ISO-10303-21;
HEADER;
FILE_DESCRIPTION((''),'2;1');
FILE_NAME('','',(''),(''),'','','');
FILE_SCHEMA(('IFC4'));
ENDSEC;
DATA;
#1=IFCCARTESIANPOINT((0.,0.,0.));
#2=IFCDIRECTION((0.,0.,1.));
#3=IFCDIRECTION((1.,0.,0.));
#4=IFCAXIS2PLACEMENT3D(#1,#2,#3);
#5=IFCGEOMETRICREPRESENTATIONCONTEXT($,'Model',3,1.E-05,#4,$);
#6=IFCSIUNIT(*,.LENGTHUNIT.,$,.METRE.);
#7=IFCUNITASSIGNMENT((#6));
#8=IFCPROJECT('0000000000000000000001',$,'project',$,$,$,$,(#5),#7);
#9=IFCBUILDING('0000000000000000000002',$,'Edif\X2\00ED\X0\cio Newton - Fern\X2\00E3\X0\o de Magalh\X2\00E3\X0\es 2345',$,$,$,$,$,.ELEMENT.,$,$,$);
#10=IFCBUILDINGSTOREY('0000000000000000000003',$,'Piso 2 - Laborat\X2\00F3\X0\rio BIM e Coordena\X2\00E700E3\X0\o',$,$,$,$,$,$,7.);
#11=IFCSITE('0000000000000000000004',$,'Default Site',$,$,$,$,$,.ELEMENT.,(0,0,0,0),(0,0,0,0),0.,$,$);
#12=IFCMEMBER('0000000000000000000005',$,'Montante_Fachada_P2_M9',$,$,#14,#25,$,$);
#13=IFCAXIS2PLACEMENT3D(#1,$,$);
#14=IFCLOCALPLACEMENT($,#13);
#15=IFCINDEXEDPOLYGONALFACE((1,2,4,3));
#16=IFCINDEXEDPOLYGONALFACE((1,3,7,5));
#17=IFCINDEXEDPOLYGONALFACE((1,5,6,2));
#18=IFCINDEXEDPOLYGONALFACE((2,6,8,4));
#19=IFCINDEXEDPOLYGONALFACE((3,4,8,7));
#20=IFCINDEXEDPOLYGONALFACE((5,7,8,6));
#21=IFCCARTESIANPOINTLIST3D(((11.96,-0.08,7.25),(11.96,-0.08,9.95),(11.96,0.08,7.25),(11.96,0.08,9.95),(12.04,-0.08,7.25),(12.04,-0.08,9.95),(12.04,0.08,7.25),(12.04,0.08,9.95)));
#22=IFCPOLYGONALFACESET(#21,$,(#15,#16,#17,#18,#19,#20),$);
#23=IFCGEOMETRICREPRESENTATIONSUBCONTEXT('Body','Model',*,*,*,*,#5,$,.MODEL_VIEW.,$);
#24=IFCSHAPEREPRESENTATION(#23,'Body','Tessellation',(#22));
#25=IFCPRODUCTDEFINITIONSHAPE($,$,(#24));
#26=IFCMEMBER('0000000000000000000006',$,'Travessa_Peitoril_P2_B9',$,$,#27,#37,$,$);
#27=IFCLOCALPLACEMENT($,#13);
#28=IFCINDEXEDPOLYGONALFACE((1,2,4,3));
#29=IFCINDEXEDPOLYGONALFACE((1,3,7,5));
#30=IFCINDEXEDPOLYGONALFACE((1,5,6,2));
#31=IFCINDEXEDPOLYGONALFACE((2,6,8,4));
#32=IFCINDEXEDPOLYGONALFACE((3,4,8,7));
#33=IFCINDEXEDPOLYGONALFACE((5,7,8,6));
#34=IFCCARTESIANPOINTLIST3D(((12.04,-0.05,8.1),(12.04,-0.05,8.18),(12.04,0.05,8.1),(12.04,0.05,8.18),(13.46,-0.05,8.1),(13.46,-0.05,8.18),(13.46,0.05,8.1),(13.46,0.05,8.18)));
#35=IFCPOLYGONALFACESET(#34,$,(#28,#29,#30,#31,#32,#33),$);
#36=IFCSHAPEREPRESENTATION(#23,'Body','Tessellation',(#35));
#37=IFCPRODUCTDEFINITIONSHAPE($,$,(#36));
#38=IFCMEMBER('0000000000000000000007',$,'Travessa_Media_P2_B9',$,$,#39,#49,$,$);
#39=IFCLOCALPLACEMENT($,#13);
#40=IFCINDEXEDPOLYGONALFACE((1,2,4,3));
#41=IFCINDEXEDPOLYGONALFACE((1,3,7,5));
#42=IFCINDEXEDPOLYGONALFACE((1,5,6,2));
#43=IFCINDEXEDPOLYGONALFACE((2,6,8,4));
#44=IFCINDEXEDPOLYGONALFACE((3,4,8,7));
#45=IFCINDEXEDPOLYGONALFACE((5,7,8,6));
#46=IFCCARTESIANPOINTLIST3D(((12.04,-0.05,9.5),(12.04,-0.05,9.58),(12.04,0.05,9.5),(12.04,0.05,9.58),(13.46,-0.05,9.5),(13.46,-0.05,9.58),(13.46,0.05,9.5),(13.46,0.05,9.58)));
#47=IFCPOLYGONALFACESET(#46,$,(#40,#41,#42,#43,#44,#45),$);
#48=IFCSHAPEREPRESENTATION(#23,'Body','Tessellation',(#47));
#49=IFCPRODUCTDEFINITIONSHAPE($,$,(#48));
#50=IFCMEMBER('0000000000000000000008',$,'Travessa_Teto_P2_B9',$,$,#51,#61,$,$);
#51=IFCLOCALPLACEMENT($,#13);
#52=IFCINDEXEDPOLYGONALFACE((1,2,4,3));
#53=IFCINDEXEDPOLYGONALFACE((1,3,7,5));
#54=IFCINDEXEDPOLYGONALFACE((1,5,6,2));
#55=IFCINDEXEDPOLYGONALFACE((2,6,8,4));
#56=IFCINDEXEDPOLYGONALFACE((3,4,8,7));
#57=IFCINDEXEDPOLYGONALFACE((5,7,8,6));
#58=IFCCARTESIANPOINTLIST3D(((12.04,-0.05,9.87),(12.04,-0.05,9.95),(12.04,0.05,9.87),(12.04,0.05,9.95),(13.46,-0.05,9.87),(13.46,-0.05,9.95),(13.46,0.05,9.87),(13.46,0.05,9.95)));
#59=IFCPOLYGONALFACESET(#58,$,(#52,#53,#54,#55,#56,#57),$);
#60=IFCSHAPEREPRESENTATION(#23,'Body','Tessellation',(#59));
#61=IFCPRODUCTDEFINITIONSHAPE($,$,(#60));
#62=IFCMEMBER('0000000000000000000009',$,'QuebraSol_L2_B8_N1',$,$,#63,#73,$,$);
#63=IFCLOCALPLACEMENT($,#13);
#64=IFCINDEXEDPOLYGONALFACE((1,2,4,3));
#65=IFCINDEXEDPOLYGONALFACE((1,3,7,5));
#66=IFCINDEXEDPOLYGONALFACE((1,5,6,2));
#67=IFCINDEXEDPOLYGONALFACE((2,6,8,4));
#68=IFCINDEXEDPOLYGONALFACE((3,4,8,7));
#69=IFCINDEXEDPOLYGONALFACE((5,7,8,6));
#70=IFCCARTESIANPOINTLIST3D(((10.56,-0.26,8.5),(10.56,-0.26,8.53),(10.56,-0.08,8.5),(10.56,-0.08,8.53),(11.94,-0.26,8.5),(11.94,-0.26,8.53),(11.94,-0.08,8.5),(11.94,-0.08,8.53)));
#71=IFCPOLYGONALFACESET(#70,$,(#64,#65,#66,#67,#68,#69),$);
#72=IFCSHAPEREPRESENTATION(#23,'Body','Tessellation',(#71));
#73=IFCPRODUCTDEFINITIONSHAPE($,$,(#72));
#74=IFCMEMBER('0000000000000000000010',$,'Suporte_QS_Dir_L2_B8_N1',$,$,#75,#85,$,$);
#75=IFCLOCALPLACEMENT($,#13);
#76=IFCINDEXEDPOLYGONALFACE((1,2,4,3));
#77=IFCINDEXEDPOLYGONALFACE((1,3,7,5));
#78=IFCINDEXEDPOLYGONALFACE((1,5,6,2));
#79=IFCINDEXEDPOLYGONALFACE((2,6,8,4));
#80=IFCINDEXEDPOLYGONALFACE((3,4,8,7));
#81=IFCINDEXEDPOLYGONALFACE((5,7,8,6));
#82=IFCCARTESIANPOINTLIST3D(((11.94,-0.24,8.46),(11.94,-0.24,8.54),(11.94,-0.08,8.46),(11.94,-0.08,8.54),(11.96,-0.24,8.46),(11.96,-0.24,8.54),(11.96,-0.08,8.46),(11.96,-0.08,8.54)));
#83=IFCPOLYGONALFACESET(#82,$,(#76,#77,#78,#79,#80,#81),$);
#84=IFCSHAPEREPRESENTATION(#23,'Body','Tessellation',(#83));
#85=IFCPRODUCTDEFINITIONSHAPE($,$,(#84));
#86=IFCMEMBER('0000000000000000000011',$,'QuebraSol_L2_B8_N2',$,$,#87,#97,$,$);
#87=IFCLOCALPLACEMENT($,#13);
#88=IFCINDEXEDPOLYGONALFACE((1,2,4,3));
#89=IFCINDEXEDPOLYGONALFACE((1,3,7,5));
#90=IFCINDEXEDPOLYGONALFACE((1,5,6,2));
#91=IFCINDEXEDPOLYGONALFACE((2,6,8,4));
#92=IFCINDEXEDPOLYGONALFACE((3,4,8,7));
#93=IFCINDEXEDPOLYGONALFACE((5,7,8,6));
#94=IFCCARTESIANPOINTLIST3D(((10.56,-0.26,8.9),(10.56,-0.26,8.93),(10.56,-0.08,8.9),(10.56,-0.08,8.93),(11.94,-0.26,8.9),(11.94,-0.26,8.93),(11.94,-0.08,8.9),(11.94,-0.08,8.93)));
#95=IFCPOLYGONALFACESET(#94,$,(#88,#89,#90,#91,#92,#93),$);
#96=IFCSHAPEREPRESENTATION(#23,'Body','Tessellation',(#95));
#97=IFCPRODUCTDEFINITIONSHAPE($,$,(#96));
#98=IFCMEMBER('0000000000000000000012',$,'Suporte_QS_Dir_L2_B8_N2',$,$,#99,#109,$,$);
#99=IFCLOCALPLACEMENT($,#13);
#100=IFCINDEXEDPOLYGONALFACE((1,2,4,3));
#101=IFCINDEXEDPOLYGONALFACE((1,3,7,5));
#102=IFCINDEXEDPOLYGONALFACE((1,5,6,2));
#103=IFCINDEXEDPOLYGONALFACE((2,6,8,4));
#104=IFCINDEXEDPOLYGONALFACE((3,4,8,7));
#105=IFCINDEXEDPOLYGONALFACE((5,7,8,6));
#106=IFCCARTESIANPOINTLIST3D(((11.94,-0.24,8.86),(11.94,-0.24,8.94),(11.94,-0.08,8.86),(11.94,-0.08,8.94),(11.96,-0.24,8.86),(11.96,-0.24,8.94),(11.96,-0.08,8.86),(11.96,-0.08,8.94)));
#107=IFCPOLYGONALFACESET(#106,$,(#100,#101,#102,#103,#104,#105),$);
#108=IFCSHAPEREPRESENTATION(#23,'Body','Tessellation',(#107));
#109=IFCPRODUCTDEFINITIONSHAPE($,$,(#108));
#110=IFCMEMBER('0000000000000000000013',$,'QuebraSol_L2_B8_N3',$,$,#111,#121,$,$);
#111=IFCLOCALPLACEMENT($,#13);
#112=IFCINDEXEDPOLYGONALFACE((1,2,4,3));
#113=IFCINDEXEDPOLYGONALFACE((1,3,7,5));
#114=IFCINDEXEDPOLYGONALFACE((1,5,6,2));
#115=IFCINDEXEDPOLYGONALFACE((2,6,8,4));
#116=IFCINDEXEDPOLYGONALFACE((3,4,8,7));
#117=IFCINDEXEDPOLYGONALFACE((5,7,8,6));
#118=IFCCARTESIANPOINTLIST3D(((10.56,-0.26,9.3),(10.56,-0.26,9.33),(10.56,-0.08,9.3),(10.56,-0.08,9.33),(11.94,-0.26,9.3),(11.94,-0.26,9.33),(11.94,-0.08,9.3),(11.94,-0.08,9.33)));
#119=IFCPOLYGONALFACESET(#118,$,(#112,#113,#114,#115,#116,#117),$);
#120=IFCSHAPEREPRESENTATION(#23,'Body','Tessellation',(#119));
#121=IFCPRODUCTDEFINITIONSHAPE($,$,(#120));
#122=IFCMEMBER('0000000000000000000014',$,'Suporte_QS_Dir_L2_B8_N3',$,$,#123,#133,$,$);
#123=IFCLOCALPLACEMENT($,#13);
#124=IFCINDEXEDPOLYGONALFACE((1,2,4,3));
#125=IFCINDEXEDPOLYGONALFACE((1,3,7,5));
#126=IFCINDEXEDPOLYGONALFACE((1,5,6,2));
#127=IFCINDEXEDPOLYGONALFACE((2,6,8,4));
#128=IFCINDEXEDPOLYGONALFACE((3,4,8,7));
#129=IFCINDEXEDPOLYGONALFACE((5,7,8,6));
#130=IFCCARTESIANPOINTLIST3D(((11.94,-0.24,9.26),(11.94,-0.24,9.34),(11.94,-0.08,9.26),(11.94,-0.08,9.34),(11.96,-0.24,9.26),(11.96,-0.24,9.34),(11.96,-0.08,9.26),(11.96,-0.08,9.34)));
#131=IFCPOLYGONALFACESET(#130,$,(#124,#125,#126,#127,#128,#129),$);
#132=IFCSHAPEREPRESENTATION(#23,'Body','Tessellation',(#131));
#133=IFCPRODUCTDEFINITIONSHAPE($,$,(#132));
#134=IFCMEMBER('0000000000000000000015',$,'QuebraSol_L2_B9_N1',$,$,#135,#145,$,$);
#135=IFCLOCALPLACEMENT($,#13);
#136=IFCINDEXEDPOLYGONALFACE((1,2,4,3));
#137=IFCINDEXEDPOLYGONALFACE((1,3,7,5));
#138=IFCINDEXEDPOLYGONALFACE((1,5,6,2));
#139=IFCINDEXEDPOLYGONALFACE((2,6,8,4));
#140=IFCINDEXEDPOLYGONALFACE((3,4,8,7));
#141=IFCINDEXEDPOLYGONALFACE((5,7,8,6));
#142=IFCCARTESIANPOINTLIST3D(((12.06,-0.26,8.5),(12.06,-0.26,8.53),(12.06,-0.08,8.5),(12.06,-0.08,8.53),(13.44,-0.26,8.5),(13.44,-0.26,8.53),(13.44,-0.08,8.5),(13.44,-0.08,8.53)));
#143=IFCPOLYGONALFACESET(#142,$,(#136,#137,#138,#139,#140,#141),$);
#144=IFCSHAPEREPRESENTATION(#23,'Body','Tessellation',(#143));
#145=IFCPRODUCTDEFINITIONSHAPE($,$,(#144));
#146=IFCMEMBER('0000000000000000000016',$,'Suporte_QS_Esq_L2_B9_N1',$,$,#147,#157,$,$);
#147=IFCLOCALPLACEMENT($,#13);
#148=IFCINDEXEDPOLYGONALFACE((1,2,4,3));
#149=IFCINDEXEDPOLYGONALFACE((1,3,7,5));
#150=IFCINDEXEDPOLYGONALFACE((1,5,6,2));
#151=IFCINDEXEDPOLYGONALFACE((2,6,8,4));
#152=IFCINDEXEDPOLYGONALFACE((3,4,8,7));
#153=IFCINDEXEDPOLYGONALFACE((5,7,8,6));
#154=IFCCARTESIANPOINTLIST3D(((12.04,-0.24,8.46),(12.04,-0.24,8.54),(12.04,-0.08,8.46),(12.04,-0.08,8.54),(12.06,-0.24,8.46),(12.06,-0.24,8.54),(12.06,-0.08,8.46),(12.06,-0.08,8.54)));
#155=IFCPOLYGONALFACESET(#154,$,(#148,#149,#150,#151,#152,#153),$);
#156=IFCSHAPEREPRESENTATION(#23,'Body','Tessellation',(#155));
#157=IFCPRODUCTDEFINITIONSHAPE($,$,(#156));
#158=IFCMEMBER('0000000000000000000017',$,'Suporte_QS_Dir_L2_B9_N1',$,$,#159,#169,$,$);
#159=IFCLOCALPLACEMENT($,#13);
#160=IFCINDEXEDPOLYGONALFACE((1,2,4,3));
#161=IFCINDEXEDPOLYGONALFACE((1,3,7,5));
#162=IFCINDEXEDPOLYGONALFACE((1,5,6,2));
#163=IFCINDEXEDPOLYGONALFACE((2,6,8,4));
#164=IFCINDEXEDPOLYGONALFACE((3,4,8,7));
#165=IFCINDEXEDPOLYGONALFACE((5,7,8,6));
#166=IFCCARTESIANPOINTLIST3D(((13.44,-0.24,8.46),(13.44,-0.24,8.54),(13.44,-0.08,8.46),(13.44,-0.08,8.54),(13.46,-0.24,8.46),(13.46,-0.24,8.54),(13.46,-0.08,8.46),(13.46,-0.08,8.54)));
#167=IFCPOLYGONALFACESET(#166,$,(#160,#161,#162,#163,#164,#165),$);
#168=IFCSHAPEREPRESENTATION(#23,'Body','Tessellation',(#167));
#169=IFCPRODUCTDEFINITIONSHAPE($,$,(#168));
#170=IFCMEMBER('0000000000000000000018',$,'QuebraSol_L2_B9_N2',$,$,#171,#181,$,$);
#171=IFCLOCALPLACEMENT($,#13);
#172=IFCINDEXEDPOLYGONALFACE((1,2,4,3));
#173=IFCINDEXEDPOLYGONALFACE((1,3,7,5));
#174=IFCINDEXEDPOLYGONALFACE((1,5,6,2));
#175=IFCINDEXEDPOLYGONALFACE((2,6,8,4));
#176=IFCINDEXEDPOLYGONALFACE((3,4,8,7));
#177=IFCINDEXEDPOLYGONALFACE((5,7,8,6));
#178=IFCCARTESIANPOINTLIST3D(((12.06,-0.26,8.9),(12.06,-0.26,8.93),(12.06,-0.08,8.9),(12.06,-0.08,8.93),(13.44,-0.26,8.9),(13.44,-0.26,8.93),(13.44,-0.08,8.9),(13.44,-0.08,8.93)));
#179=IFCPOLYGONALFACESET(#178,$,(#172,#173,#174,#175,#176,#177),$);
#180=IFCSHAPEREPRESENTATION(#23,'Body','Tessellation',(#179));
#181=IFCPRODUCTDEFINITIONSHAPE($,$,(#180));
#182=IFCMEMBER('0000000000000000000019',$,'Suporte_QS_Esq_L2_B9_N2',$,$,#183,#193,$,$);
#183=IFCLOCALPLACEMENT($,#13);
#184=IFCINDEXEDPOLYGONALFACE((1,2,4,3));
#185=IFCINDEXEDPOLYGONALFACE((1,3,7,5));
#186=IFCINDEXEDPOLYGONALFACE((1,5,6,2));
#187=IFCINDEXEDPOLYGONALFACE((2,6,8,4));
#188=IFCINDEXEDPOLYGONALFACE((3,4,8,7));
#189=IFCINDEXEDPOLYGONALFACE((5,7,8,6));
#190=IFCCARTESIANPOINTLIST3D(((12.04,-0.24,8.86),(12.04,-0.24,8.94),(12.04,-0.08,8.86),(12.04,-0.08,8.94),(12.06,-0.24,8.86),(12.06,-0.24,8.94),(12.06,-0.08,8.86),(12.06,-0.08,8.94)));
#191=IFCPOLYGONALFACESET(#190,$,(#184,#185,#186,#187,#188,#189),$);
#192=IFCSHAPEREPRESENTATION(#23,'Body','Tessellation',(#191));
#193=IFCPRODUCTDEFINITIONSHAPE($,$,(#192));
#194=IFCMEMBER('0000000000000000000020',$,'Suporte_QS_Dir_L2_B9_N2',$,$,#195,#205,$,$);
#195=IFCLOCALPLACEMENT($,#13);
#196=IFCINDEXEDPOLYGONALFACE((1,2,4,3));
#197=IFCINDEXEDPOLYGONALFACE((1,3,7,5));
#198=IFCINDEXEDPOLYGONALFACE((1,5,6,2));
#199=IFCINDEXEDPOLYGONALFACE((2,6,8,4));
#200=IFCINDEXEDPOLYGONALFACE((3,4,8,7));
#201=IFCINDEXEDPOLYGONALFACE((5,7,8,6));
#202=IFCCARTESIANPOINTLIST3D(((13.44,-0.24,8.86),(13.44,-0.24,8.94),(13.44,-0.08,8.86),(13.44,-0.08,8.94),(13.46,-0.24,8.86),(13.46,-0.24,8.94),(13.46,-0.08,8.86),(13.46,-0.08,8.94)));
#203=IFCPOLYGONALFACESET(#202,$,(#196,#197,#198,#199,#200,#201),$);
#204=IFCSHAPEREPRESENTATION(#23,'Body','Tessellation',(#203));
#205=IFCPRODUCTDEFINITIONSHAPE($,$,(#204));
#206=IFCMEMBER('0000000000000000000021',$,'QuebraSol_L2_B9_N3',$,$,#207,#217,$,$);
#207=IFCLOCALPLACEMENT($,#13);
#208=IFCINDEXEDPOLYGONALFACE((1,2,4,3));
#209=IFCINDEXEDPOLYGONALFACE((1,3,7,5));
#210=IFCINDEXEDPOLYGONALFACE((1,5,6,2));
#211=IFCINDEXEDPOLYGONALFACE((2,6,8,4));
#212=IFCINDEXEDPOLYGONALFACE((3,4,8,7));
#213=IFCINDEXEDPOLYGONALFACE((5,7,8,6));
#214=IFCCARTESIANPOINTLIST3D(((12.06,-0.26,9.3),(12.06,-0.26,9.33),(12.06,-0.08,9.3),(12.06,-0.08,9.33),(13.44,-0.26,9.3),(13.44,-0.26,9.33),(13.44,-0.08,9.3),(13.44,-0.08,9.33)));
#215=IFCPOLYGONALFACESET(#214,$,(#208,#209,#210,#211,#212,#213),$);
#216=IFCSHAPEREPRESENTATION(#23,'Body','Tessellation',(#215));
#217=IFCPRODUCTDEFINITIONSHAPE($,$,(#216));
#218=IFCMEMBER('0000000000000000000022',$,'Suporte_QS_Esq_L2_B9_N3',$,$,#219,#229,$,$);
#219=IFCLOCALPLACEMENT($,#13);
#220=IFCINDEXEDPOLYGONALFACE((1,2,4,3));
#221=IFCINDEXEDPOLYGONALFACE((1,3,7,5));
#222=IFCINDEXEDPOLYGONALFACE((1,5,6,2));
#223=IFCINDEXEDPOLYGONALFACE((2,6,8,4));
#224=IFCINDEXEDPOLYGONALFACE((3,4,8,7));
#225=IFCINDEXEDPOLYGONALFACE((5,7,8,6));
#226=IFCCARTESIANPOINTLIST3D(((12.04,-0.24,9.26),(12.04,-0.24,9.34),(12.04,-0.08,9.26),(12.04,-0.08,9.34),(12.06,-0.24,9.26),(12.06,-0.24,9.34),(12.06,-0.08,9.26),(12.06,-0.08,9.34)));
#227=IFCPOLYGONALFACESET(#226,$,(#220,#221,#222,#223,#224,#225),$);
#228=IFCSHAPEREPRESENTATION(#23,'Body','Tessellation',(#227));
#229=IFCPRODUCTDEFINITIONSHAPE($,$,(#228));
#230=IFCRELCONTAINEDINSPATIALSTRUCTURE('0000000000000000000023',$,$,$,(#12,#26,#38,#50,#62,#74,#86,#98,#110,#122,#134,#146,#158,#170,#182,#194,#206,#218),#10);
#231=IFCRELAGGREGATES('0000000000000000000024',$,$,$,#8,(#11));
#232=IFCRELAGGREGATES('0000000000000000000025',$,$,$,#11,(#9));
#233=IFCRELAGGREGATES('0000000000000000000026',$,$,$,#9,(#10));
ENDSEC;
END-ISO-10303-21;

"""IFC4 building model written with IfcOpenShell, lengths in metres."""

from ifc_helpers import new_model, si_unit, frame, frame_2d, origin_with_axes, place, context, subcontext, project, spatial, rectangle, extrude, element, save


model = new_model("IFC4")

# Units and contexts
model_context = context("Model", 3, precision=1e-05, world=origin_with_axes())
body_context = subcontext(model_context, "Body", "Model", "MODEL_VIEW")
ifc_project = project(units=[si_unit("LENGTHUNIT", "METRE")], contexts=[model_context])

# Site, building, storey
site = spatial("IfcSite", under=ifc_project, Name="Default Site", CompositionType="ELEMENT", RefLatitude=(0, 0, 0, 0), RefLongitude=(0, 0, 0, 0), RefElevation=0.0)
building = spatial("IfcBuilding", under=site, Name="Edifício Newton - Fernão de Magalhães 2345", CompositionType="ELEMENT")
storey = spatial("IfcBuildingStorey", under=building, Name="Piso 2 - Laboratório BIM e Coordenação", Elevation=7.0)

# Members
member_1_placement = place(None, frame((11.96, -0.08, 7.25), z_axis=(0.0, 0.0, 1.0), x_axis=(1.0, 0.0, 0.0)))
element("IfcMember", 1, at=member_1_placement, inside=storey, Name="Montante_Fachada_P2_M9", context=body_context, shape_type="SweptSolid", body=[
    extrude(rectangle(XDim=0.08, YDim=0.16, at=frame_2d((0.04, 0.08))), origin_with_axes(), (0.0, 0.0, 1.0), 2.7),
])
for number, where, z_axis, x_axis, name in (
    (2, (12.04, -0.05, 8.1), (0.0, 0.0, 1.0), (1.0, 0.0, 0.0), "Travessa_Peitoril_P2_B9"),
    (3, (12.04, -0.05, 9.5), (0.0, 0.0, 1.0), (1.0, 0.0, 0.0), "Travessa_Media_P2_B9"),
    (4, (12.04, -0.05, 9.87), (0.0, 0.0, 1.0), (1.0, 0.0, 0.0), "Travessa_Teto_P2_B9"),
):
    element("IfcMember", number, at=place(None, frame(where, z_axis=z_axis, x_axis=x_axis)), inside=storey, Name=name, context=body_context, shape_type="SweptSolid", body=[
        extrude(rectangle(XDim=1.42, YDim=0.1, at=frame_2d((0.71, 0.05))), origin_with_axes(), (0.0, 0.0, 1.0), 0.08),
    ])
member_2_placement = place(None, frame((10.56, -0.26, 8.5), z_axis=(0.0, 0.0, 1.0), x_axis=(1.0, 0.0, 0.0)))
element("IfcMember", 5, at=member_2_placement, inside=storey, Name="QuebraSol_L2_B8_N1", context=body_context, shape_type="SweptSolid", body=[
    extrude(rectangle(XDim=1.38, YDim=0.18, at=frame_2d((0.69, 0.09))), origin_with_axes(), (0.0, 0.0, 1.0), 0.03),
])
member_3_placement = place(None, frame((11.94, -0.24, 8.46), z_axis=(0.0, 0.0, 1.0), x_axis=(1.0, 0.0, 0.0)))
element("IfcMember", 6, at=member_3_placement, inside=storey, Name="Suporte_QS_Dir_L2_B8_N1", context=body_context, shape_type="SweptSolid", body=[
    extrude(rectangle(XDim=0.02, YDim=0.16, at=frame_2d((0.01, 0.08))), origin_with_axes(), (0.0, 0.0, 1.0), 0.08),
])
member_4_placement = place(None, frame((10.56, -0.26, 8.9), z_axis=(0.0, 0.0, 1.0), x_axis=(1.0, 0.0, 0.0)))
element("IfcMember", 7, at=member_4_placement, inside=storey, Name="QuebraSol_L2_B8_N2", context=body_context, shape_type="SweptSolid", body=[
    extrude(rectangle(XDim=1.38, YDim=0.18, at=frame_2d((0.69, 0.09))), origin_with_axes(), (0.0, 0.0, 1.0), 0.03),
])
member_5_placement = place(None, frame((11.94, -0.24, 8.86), z_axis=(0.0, 0.0, 1.0), x_axis=(1.0, 0.0, 0.0)))
element("IfcMember", 8, at=member_5_placement, inside=storey, Name="Suporte_QS_Dir_L2_B8_N2", context=body_context, shape_type="SweptSolid", body=[
    extrude(rectangle(XDim=0.02, YDim=0.16, at=frame_2d((0.01, 0.08))), origin_with_axes(), (0.0, 0.0, 1.0), 0.08),
])
member_6_placement = place(None, frame((10.56, -0.26, 9.3), z_axis=(0.0, 0.0, 1.0), x_axis=(1.0, 0.0, 0.0)))
element("IfcMember", 9, at=member_6_placement, inside=storey, Name="QuebraSol_L2_B8_N3", context=body_context, shape_type="SweptSolid", body=[
    extrude(rectangle(XDim=1.38, YDim=0.18, at=frame_2d((0.69, 0.09))), origin_with_axes(), (0.0, 0.0, 1.0), 0.03),
])
member_7_placement = place(None, frame((11.94, -0.24, 9.26), z_axis=(0.0, 0.0, 1.0), x_axis=(1.0, 0.0, 0.0)))
element("IfcMember", 10, at=member_7_placement, inside=storey, Name="Suporte_QS_Dir_L2_B8_N3", context=body_context, shape_type="SweptSolid", body=[
    extrude(rectangle(XDim=0.02, YDim=0.16, at=frame_2d((0.01, 0.08))), origin_with_axes(), (0.0, 0.0, 1.0), 0.08),
])
member_8_placement = place(None, frame((12.06, -0.26, 8.5), z_axis=(0.0, 0.0, 1.0), x_axis=(1.0, 0.0, 0.0)))
element("IfcMember", 11, at=member_8_placement, inside=storey, Name="QuebraSol_L2_B9_N1", context=body_context, shape_type="SweptSolid", body=[
    extrude(rectangle(XDim=1.38, YDim=0.18, at=frame_2d((0.69, 0.09))), origin_with_axes(), (0.0, 0.0, 1.0), 0.03),
])
for number, where, z_axis, x_axis, name in (
    (12, (12.04, -0.24, 8.46), (0.0, 0.0, 1.0), (1.0, 0.0, 0.0), "Suporte_QS_Esq_L2_B9_N1"),
    (13, (13.44, -0.24, 8.46), (0.0, 0.0, 1.0), (1.0, 0.0, 0.0), "Suporte_QS_Dir_L2_B9_N1"),
):
    element("IfcMember", number, at=place(None, frame(where, z_axis=z_axis, x_axis=x_axis)), inside=storey, Name=name, context=body_context, shape_type="SweptSolid", body=[
        extrude(rectangle(XDim=0.02, YDim=0.16, at=frame_2d((0.01, 0.08))), origin_with_axes(), (0.0, 0.0, 1.0), 0.08),
    ])
member_9_placement = place(None, frame((12.06, -0.26, 8.9), z_axis=(0.0, 0.0, 1.0), x_axis=(1.0, 0.0, 0.0)))
element("IfcMember", 14, at=member_9_placement, inside=storey, Name="QuebraSol_L2_B9_N2", context=body_context, shape_type="SweptSolid", body=[
    extrude(rectangle(XDim=1.38, YDim=0.18, at=frame_2d((0.69, 0.09))), origin_with_axes(), (0.0, 0.0, 1.0), 0.03),
])
for number, where, z_axis, x_axis, name in (
    (15, (12.04, -0.24, 8.86), (0.0, 0.0, 1.0), (1.0, 0.0, 0.0), "Suporte_QS_Esq_L2_B9_N2"),
    (16, (13.44, -0.24, 8.86), (0.0, 0.0, 1.0), (1.0, 0.0, 0.0), "Suporte_QS_Dir_L2_B9_N2"),
):
    element("IfcMember", number, at=place(None, frame(where, z_axis=z_axis, x_axis=x_axis)), inside=storey, Name=name, context=body_context, shape_type="SweptSolid", body=[
        extrude(rectangle(XDim=0.02, YDim=0.16, at=frame_2d((0.01, 0.08))), origin_with_axes(), (0.0, 0.0, 1.0), 0.08),
    ])
member_10_placement = place(None, frame((12.06, -0.26, 9.3), z_axis=(0.0, 0.0, 1.0), x_axis=(1.0, 0.0, 0.0)))
element("IfcMember", 17, at=member_10_placement, inside=storey, Name="QuebraSol_L2_B9_N3", context=body_context, shape_type="SweptSolid", body=[
    extrude(rectangle(XDim=1.38, YDim=0.18, at=frame_2d((0.69, 0.09))), origin_with_axes(), (0.0, 0.0, 1.0), 0.03),
])
member_11_placement = place(None, frame((12.04, -0.24, 9.26), z_axis=(0.0, 0.0, 1.0), x_axis=(1.0, 0.0, 0.0)))
element("IfcMember", 18, at=member_11_placement, inside=storey, Name="Suporte_QS_Esq_L2_B9_N3", context=body_context, shape_type="SweptSolid", body=[
    extrude(rectangle(XDim=0.02, YDim=0.16, at=frame_2d((0.01, 0.08))), origin_with_axes(), (0.0, 0.0, 1.0), 0.08),
])

save(model, "model.ifc")
